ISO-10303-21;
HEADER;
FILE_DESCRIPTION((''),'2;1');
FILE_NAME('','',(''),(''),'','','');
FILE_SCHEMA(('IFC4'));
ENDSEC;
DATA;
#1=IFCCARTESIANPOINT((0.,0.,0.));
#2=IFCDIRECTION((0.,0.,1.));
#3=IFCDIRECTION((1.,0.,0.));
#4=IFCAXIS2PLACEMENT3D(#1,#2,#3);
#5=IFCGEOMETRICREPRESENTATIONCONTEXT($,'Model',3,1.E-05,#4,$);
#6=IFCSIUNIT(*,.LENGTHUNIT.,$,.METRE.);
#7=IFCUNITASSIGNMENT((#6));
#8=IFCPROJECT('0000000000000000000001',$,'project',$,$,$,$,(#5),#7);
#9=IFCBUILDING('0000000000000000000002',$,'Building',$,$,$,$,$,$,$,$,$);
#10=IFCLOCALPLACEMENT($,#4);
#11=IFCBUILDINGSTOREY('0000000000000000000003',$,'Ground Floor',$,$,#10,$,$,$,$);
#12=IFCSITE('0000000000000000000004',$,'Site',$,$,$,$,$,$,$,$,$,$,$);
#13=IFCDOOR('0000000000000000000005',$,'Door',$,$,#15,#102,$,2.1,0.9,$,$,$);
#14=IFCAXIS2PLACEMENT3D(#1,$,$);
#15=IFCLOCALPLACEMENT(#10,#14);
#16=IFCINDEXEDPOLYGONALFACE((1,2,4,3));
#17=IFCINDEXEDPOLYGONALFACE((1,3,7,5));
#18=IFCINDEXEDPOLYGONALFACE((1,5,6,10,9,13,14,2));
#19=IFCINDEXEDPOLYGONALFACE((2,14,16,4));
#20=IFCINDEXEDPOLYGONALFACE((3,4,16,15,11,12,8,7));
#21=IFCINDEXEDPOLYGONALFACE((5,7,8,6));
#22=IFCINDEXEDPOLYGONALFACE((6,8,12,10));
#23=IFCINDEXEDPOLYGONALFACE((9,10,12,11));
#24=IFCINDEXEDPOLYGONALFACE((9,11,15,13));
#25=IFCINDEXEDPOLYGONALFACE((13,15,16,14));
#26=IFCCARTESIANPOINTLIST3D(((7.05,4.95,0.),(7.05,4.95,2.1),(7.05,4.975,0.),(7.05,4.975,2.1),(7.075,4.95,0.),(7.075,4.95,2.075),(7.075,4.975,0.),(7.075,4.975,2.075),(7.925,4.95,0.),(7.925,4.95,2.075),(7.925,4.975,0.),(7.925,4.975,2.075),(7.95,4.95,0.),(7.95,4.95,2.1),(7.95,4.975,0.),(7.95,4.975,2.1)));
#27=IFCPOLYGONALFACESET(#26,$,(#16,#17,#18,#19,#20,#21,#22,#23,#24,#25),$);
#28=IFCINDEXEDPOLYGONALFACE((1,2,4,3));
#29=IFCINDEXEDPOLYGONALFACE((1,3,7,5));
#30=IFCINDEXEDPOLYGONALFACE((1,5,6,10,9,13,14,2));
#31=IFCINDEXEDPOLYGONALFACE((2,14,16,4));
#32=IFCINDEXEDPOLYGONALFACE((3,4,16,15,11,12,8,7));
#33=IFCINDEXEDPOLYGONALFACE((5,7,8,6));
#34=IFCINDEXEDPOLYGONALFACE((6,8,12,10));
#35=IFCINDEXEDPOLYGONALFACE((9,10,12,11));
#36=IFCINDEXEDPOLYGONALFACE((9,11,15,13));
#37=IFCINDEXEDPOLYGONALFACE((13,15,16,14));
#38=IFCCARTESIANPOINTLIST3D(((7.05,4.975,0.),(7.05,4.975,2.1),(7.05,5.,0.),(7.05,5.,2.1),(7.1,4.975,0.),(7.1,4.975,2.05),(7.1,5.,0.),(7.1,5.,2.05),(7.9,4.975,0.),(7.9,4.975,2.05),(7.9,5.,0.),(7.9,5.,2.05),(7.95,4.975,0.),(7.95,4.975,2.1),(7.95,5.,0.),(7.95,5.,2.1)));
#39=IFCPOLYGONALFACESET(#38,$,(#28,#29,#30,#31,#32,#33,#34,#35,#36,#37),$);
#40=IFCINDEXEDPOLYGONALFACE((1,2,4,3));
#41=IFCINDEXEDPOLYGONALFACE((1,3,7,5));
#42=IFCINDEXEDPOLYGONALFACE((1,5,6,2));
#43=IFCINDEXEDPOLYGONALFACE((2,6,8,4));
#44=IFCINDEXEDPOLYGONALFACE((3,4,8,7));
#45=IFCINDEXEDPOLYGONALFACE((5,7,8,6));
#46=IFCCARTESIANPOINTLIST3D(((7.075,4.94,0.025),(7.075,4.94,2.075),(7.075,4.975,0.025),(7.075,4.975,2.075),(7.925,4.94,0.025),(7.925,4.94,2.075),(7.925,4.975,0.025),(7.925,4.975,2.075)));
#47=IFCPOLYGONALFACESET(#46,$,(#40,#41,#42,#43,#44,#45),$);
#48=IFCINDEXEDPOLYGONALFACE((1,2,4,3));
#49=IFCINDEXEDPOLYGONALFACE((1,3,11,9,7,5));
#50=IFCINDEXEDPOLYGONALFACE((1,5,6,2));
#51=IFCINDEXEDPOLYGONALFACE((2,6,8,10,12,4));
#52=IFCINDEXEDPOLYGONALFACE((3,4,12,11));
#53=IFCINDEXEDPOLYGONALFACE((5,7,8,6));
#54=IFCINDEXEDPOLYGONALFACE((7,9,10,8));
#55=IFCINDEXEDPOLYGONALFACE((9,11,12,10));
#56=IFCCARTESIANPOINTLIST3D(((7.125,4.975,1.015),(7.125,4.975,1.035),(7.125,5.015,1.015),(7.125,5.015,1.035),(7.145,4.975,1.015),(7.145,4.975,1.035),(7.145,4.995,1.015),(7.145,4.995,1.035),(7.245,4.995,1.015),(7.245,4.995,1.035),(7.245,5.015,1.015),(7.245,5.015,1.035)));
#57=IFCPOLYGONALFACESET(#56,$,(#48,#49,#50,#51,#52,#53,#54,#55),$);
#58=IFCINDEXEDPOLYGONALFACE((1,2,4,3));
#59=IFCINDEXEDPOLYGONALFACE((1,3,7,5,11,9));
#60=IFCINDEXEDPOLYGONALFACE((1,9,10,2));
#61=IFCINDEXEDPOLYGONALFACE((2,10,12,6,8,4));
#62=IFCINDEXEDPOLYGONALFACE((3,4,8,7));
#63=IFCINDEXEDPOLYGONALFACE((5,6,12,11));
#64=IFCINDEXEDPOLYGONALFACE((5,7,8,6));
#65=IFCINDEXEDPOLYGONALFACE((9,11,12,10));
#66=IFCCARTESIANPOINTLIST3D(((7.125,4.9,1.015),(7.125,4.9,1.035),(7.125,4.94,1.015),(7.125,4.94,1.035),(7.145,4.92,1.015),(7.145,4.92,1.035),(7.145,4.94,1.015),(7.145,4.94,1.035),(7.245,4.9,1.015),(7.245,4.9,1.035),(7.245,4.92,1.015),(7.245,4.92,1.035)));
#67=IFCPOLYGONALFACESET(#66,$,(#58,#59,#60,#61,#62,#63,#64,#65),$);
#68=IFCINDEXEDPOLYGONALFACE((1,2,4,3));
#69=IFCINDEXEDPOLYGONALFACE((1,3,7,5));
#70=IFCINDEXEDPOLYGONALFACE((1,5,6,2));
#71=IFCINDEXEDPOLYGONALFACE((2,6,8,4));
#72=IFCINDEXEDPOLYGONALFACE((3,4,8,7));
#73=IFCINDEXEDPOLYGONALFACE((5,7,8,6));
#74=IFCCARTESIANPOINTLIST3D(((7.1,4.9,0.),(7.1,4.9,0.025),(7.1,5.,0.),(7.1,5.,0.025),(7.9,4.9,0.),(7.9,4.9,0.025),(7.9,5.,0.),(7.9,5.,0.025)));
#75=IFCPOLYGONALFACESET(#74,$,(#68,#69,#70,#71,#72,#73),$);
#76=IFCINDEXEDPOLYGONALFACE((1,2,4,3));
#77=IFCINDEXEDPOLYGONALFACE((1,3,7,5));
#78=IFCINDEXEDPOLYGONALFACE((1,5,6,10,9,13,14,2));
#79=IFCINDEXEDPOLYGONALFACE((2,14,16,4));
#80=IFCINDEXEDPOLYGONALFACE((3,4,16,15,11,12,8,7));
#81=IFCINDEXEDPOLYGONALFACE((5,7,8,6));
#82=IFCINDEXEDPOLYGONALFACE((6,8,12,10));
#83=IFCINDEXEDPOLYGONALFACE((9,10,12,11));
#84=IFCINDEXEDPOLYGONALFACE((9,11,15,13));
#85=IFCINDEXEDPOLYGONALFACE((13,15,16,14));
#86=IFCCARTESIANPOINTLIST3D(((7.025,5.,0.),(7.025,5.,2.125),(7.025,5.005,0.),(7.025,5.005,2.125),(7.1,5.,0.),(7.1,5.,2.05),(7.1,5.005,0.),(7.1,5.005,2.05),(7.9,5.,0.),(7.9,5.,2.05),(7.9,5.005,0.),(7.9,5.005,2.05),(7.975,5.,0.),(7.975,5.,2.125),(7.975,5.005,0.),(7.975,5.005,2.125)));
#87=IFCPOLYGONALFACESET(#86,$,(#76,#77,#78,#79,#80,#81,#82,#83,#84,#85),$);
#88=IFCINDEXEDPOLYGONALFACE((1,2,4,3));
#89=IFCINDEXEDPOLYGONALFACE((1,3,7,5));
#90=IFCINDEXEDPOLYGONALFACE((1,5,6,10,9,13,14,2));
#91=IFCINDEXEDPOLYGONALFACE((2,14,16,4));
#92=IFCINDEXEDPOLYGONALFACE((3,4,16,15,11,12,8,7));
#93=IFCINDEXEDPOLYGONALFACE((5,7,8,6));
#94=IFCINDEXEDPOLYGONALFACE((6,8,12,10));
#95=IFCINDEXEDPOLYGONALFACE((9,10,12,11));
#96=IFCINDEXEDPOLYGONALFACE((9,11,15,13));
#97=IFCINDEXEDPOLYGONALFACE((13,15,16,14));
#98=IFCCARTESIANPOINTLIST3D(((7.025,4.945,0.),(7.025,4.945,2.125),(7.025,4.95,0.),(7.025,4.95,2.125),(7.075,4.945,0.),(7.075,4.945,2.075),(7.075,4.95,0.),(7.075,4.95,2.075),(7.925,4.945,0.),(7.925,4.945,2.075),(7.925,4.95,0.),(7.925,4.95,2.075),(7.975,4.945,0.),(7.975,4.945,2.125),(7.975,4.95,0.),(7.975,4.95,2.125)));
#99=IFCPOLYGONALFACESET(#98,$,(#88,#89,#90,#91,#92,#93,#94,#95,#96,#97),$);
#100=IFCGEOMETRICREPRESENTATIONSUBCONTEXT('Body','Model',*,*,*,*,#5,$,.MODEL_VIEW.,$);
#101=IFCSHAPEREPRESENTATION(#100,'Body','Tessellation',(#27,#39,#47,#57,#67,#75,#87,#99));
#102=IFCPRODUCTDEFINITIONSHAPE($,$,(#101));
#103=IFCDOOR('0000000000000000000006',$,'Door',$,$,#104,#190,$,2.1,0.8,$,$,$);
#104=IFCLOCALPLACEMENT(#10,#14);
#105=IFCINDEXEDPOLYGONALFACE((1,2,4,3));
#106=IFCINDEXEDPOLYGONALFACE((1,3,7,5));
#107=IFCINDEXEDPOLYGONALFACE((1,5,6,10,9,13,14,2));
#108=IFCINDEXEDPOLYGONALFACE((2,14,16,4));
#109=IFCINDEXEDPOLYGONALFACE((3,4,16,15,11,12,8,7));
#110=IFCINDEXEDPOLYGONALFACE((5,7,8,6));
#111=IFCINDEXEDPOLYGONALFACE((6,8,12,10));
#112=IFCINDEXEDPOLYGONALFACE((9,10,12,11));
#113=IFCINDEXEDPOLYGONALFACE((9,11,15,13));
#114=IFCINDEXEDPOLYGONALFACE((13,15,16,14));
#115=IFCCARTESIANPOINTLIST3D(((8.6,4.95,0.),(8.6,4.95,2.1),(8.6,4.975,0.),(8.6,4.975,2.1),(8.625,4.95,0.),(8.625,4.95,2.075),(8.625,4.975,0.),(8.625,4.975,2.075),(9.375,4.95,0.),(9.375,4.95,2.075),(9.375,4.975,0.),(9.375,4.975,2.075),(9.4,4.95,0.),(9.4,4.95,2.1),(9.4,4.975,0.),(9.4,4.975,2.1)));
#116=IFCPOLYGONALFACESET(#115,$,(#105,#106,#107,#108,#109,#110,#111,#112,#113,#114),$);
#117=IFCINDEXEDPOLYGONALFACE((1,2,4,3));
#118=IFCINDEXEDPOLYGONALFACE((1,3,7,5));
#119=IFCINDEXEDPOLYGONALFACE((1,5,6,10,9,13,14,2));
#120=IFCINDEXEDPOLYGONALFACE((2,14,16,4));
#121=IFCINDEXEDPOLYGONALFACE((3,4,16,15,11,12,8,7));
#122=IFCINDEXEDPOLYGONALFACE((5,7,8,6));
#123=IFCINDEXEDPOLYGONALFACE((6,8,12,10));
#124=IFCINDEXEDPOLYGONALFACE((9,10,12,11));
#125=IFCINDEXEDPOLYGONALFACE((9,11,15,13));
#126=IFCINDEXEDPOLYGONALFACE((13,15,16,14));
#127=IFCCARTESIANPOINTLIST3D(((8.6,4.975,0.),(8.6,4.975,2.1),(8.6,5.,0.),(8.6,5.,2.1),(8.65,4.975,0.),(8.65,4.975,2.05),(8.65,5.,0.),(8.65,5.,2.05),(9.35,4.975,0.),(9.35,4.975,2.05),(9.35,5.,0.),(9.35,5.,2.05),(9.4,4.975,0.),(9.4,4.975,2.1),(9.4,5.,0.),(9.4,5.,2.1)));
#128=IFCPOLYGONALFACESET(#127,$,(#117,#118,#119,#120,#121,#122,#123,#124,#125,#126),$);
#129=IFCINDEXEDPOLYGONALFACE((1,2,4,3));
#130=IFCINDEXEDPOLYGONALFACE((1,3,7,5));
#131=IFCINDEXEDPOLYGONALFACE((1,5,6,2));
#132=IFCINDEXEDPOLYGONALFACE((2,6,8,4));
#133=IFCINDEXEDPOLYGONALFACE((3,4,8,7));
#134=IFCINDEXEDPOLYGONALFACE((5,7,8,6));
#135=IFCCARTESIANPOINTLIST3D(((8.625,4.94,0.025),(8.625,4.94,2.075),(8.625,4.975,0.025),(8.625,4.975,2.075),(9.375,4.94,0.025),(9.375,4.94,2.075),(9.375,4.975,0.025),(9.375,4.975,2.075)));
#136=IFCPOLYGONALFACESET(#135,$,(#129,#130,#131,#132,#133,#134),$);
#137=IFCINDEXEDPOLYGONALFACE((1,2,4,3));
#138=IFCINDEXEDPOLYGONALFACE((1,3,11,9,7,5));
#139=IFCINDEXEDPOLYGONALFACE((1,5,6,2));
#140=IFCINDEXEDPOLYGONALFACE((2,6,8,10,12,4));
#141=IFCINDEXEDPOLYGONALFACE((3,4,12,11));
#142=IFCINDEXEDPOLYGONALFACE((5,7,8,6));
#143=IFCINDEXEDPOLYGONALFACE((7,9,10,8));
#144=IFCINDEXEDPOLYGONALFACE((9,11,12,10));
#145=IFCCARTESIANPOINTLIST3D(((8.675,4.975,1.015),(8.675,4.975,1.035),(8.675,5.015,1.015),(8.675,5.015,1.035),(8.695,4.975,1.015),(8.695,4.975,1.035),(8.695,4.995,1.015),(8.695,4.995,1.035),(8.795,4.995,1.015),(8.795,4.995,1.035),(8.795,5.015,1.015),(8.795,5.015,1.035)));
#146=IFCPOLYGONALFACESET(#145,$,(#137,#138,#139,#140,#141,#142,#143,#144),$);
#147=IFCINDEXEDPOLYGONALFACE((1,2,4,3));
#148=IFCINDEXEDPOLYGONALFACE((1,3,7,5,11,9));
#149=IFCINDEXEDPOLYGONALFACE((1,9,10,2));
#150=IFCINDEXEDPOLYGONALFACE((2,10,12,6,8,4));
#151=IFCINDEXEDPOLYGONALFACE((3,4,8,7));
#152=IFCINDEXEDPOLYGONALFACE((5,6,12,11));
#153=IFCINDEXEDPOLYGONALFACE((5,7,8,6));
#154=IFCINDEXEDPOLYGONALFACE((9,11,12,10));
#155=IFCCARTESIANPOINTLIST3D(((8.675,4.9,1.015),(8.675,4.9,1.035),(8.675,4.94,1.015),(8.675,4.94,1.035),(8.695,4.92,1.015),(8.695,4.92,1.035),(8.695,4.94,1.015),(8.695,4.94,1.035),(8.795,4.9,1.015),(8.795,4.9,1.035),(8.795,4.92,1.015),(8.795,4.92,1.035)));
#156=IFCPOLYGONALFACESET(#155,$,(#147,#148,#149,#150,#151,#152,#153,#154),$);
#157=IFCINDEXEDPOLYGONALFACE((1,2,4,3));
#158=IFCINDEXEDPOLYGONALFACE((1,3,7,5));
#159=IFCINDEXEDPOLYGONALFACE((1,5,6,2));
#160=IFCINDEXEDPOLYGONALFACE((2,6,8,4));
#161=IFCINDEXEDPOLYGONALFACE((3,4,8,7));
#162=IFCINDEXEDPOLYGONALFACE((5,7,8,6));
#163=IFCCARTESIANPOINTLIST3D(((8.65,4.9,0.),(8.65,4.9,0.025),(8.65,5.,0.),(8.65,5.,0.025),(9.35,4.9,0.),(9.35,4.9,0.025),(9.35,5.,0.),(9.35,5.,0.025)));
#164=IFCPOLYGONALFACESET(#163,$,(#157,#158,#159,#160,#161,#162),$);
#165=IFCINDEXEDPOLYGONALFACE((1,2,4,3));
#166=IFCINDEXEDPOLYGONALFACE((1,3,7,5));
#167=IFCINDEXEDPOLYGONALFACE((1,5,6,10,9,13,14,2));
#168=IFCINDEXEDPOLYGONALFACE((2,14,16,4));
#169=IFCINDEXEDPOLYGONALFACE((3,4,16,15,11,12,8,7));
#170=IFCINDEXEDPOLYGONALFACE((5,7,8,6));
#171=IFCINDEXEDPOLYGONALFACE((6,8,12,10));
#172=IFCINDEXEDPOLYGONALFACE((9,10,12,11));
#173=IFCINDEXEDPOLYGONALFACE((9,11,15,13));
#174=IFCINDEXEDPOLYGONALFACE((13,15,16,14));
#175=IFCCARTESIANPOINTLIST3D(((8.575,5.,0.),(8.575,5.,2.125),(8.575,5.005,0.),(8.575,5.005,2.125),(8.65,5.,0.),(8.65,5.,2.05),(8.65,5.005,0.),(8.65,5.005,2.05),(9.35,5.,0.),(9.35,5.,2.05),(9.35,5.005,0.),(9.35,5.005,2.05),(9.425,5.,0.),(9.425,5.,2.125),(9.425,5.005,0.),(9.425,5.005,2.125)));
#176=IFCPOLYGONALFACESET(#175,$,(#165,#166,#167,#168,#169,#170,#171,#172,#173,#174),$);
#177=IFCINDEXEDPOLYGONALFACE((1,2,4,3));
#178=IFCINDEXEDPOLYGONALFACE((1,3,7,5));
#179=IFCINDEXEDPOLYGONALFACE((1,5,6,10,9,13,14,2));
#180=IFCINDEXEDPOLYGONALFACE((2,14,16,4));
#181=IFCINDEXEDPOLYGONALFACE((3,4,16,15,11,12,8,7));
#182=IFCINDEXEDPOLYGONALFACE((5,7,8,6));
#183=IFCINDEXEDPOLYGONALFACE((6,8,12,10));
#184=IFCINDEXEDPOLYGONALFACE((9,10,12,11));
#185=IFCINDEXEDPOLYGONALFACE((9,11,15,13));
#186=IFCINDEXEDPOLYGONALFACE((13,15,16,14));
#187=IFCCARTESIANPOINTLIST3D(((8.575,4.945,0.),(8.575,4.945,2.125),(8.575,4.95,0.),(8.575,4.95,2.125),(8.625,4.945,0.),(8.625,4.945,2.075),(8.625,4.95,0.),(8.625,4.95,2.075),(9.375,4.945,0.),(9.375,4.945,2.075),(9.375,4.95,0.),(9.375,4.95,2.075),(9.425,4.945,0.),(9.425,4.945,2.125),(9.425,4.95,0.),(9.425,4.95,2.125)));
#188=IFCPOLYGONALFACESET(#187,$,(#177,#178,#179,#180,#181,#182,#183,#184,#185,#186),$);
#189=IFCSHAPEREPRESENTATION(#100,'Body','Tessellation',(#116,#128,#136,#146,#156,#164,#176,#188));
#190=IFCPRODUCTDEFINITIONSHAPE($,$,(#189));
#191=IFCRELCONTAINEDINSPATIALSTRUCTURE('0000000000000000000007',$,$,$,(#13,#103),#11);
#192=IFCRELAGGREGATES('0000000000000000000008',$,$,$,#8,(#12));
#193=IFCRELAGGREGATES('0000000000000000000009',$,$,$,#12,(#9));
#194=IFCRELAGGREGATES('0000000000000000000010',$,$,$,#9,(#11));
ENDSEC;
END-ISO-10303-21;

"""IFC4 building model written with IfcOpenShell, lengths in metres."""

from ifc_helpers import new_model, si_unit, frame, origin_with_axes, place, context, subcontext, project, spatial, line, indexed_curve, outline, extrude, element, save


model = new_model("IFC4")

# Units and contexts
model_context = context("Model", 3, precision=1e-05, world=origin_with_axes())
body_context = subcontext(model_context, "Body", "Model", "MODEL_VIEW")
ifc_project = project(units=[si_unit("LENGTHUNIT", "METRE")], contexts=[model_context])

# Site, building, storey
site = spatial("IfcSite", under=ifc_project, Name="Site")
building = spatial("IfcBuilding", under=site, Name="Building")
storey_placement = place(None, origin_with_axes())
storey = spatial("IfcBuildingStorey", under=building, at=storey_placement, Name="Ground Floor")

# Doors
door_1_placement = place(storey_placement, frame((7.95, 5.0, 0.0), z_axis=(0.0, 0.0, 1.0), x_axis=(-1.0, 0.0, 0.0)))
element("IfcDoor", 1, at=door_1_placement, inside=storey, Name="Door", OverallHeight=2.1, OverallWidth=0.9, context=body_context, shape_type="SweptSolid", body=[
    extrude(outline(indexed_curve([(0.0, 0.0), (0.0, 2.1), (0.9, 2.1), (0.9, 0.0), (0.875, 0.0), (0.875, 2.075), (0.025, 2.075), (0.025, 0.0)], segments=[line(1, 2, 3, 4, 5, 6, 7, 8, 1)])), frame((0.0, 0.025, 0.0), z_axis=(0.0, -1.0, 0.0), x_axis=(1.0, 0.0, 0.0)), (0.0, 0.0, -1.0), 0.025),
    extrude(outline(indexed_curve([(0.0, 0.0), (0.0, 2.1), (0.9, 2.1), (0.9, 0.0), (0.85, 0.0), (0.85, 2.05), (0.05, 2.05), (0.05, 0.0)], segments=[line(1, 2, 3, 4, 5, 6, 7, 8, 1)])), frame((0.0, 0.0, 0.0), z_axis=(0.0, -1.0, 0.0), x_axis=(1.0, 0.0, 0.0)), (0.0, 0.0, -1.0), 0.025),
    extrude(outline(indexed_curve([(0.0, 0.0), (0.85, 0.0), (0.85, 0.035), (0.0, 0.035)], segments=[line(1, 2, 3, 4, 1)])), frame((0.025, 0.025, 0.025), z_axis=(0.0, 0.0, 1.0), x_axis=(1.0, 0.0, 0.0)), (0.0, 0.0, 1.0), 2.05),
    extrude(outline(indexed_curve([(0.0, 0.0), (0.0, -0.04), (-0.12, -0.04), (-0.12, -0.02), (-0.02, -0.02), (-0.02, 0.0)], segments=[line(1, 2, 3, 4, 5, 6, 1)])), frame((0.825, 0.025, 1.015), z_axis=(0.0, 0.0, 1.0), x_axis=(1.0, 0.0, 0.0)), (0.0, 0.0, 1.0), 0.02),
    extrude(outline(indexed_curve([(0.0, 0.0), (0.0, 0.04), (-0.12, 0.04), (-0.12, 0.02), (-0.02, 0.02), (-0.02, 0.0)], segments=[line(1, 2, 3, 4, 5, 6, 1)])), frame((0.825, 0.06, 1.015), z_axis=(0.0, 0.0, 1.0), x_axis=(1.0, 0.0, 0.0)), (0.0, 0.0, 1.0), 0.02),
    extrude(outline(indexed_curve([(0.0, 0.0), (0.8, 0.0), (0.8, 0.1), (0.0, 0.1)], segments=[line(1, 2, 3, 4, 1)])), frame((0.05, 0.0, 0.0), z_axis=(0.0, 0.0, 1.0), x_axis=(1.0, 0.0, 0.0)), (0.0, 0.0, 1.0), 0.025),
    extrude(outline(indexed_curve([(0.0, 0.0), (0.0, 2.125), (0.95, 2.125), (0.95, 0.0), (0.875, 0.0), (0.875, 2.05), (0.075, 2.05), (0.075, 0.0)], segments=[line(1, 2, 3, 4, 5, 6, 7, 8, 1)])), frame((-0.025, -0.005, 0.0), z_axis=(0.0, -1.0, 0.0), x_axis=(1.0, 0.0, 0.0)), (0.0, 0.0, -1.0), 0.005),
    extrude(outline(indexed_curve([(0.0, 0.0), (0.0, 2.125), (0.95, 2.125), (0.95, 0.0), (0.9, 0.0), (0.9, 2.075), (0.05, 2.075), (0.05, 0.0)], segments=[line(1, 2, 3, 4, 5, 6, 7, 8, 1)])), frame((-0.025, 0.05, 0.0), z_axis=(0.0, -1.0, 0.0), x_axis=(1.0, 0.0, 0.0)), (0.0, 0.0, -1.0), 0.005),
])
door_2_placement = place(storey_placement, frame((9.4, 5.0, 0.0), z_axis=(0.0, 0.0, 1.0), x_axis=(-1.0, 0.0, 0.0)))
element("IfcDoor", 2, at=door_2_placement, inside=storey, Name="Door", OverallHeight=2.1, OverallWidth=0.8, context=body_context, shape_type="SweptSolid", body=[
    extrude(outline(indexed_curve([(0.0, 0.0), (0.0, 2.1), (0.8, 2.1), (0.8, 0.0), (0.775, 0.0), (0.775, 2.075), (0.025, 2.075), (0.025, 0.0)], segments=[line(1, 2, 3, 4, 5, 6, 7, 8, 1)])), frame((0.0, 0.025, 0.0), z_axis=(0.0, -1.0, 0.0), x_axis=(1.0, 0.0, 0.0)), (0.0, 0.0, -1.0), 0.025),
    extrude(outline(indexed_curve([(0.0, 0.0), (0.0, 2.1), (0.8, 2.1), (0.8, 0.0), (0.75, 0.0), (0.75, 2.05), (0.05, 2.05), (0.05, 0.0)], segments=[line(1, 2, 3, 4, 5, 6, 7, 8, 1)])), frame((0.0, 0.0, 0.0), z_axis=(0.0, -1.0, 0.0), x_axis=(1.0, 0.0, 0.0)), (0.0, 0.0, -1.0), 0.025),
    extrude(outline(indexed_curve([(0.0, 0.0), (0.75, 0.0), (0.75, 0.035), (0.0, 0.035)], segments=[line(1, 2, 3, 4, 1)])), frame((0.025, 0.025, 0.025), z_axis=(0.0, 0.0, 1.0), x_axis=(1.0, 0.0, 0.0)), (0.0, 0.0, 1.0), 2.05),
    extrude(outline(indexed_curve([(0.0, 0.0), (0.0, -0.04), (-0.12, -0.04), (-0.12, -0.02), (-0.02, -0.02), (-0.02, 0.0)], segments=[line(1, 2, 3, 4, 5, 6, 1)])), frame((0.725, 0.025, 1.015), z_axis=(0.0, 0.0, 1.0), x_axis=(1.0, 0.0, 0.0)), (0.0, 0.0, 1.0), 0.02),
    extrude(outline(indexed_curve([(0.0, 0.0), (0.0, 0.04), (-0.12, 0.04), (-0.12, 0.02), (-0.02, 0.02), (-0.02, 0.0)], segments=[line(1, 2, 3, 4, 5, 6, 1)])), frame((0.725, 0.06, 1.015), z_axis=(0.0, 0.0, 1.0), x_axis=(1.0, 0.0, 0.0)), (0.0, 0.0, 1.0), 0.02),
    extrude(outline(indexed_curve([(0.0, 0.0), (0.7, 0.0), (0.7, 0.1), (0.0, 0.1)], segments=[line(1, 2, 3, 4, 1)])), frame((0.05, 0.0, 0.0), z_axis=(0.0, 0.0, 1.0), x_axis=(1.0, 0.0, 0.0)), (0.0, 0.0, 1.0), 0.025),
    extrude(outline(indexed_curve([(0.0, 0.0), (0.0, 2.125), (0.85, 2.125), (0.85, 0.0), (0.775, 0.0), (0.775, 2.05), (0.075, 2.05), (0.075, 0.0)], segments=[line(1, 2, 3, 4, 5, 6, 7, 8, 1)])), frame((-0.025, -0.005, 0.0), z_axis=(0.0, -1.0, 0.0), x_axis=(1.0, 0.0, 0.0)), (0.0, 0.0, -1.0), 0.005),
    extrude(outline(indexed_curve([(0.0, 0.0), (0.0, 2.125), (0.85, 2.125), (0.85, 0.0), (0.8, 0.0), (0.8, 2.075), (0.05, 2.075), (0.05, 0.0)], segments=[line(1, 2, 3, 4, 5, 6, 7, 8, 1)])), frame((-0.025, 0.05, 0.0), z_axis=(0.0, -1.0, 0.0), x_axis=(1.0, 0.0, 0.0)), (0.0, 0.0, -1.0), 0.005),
])

save(model, "model.ifc")
